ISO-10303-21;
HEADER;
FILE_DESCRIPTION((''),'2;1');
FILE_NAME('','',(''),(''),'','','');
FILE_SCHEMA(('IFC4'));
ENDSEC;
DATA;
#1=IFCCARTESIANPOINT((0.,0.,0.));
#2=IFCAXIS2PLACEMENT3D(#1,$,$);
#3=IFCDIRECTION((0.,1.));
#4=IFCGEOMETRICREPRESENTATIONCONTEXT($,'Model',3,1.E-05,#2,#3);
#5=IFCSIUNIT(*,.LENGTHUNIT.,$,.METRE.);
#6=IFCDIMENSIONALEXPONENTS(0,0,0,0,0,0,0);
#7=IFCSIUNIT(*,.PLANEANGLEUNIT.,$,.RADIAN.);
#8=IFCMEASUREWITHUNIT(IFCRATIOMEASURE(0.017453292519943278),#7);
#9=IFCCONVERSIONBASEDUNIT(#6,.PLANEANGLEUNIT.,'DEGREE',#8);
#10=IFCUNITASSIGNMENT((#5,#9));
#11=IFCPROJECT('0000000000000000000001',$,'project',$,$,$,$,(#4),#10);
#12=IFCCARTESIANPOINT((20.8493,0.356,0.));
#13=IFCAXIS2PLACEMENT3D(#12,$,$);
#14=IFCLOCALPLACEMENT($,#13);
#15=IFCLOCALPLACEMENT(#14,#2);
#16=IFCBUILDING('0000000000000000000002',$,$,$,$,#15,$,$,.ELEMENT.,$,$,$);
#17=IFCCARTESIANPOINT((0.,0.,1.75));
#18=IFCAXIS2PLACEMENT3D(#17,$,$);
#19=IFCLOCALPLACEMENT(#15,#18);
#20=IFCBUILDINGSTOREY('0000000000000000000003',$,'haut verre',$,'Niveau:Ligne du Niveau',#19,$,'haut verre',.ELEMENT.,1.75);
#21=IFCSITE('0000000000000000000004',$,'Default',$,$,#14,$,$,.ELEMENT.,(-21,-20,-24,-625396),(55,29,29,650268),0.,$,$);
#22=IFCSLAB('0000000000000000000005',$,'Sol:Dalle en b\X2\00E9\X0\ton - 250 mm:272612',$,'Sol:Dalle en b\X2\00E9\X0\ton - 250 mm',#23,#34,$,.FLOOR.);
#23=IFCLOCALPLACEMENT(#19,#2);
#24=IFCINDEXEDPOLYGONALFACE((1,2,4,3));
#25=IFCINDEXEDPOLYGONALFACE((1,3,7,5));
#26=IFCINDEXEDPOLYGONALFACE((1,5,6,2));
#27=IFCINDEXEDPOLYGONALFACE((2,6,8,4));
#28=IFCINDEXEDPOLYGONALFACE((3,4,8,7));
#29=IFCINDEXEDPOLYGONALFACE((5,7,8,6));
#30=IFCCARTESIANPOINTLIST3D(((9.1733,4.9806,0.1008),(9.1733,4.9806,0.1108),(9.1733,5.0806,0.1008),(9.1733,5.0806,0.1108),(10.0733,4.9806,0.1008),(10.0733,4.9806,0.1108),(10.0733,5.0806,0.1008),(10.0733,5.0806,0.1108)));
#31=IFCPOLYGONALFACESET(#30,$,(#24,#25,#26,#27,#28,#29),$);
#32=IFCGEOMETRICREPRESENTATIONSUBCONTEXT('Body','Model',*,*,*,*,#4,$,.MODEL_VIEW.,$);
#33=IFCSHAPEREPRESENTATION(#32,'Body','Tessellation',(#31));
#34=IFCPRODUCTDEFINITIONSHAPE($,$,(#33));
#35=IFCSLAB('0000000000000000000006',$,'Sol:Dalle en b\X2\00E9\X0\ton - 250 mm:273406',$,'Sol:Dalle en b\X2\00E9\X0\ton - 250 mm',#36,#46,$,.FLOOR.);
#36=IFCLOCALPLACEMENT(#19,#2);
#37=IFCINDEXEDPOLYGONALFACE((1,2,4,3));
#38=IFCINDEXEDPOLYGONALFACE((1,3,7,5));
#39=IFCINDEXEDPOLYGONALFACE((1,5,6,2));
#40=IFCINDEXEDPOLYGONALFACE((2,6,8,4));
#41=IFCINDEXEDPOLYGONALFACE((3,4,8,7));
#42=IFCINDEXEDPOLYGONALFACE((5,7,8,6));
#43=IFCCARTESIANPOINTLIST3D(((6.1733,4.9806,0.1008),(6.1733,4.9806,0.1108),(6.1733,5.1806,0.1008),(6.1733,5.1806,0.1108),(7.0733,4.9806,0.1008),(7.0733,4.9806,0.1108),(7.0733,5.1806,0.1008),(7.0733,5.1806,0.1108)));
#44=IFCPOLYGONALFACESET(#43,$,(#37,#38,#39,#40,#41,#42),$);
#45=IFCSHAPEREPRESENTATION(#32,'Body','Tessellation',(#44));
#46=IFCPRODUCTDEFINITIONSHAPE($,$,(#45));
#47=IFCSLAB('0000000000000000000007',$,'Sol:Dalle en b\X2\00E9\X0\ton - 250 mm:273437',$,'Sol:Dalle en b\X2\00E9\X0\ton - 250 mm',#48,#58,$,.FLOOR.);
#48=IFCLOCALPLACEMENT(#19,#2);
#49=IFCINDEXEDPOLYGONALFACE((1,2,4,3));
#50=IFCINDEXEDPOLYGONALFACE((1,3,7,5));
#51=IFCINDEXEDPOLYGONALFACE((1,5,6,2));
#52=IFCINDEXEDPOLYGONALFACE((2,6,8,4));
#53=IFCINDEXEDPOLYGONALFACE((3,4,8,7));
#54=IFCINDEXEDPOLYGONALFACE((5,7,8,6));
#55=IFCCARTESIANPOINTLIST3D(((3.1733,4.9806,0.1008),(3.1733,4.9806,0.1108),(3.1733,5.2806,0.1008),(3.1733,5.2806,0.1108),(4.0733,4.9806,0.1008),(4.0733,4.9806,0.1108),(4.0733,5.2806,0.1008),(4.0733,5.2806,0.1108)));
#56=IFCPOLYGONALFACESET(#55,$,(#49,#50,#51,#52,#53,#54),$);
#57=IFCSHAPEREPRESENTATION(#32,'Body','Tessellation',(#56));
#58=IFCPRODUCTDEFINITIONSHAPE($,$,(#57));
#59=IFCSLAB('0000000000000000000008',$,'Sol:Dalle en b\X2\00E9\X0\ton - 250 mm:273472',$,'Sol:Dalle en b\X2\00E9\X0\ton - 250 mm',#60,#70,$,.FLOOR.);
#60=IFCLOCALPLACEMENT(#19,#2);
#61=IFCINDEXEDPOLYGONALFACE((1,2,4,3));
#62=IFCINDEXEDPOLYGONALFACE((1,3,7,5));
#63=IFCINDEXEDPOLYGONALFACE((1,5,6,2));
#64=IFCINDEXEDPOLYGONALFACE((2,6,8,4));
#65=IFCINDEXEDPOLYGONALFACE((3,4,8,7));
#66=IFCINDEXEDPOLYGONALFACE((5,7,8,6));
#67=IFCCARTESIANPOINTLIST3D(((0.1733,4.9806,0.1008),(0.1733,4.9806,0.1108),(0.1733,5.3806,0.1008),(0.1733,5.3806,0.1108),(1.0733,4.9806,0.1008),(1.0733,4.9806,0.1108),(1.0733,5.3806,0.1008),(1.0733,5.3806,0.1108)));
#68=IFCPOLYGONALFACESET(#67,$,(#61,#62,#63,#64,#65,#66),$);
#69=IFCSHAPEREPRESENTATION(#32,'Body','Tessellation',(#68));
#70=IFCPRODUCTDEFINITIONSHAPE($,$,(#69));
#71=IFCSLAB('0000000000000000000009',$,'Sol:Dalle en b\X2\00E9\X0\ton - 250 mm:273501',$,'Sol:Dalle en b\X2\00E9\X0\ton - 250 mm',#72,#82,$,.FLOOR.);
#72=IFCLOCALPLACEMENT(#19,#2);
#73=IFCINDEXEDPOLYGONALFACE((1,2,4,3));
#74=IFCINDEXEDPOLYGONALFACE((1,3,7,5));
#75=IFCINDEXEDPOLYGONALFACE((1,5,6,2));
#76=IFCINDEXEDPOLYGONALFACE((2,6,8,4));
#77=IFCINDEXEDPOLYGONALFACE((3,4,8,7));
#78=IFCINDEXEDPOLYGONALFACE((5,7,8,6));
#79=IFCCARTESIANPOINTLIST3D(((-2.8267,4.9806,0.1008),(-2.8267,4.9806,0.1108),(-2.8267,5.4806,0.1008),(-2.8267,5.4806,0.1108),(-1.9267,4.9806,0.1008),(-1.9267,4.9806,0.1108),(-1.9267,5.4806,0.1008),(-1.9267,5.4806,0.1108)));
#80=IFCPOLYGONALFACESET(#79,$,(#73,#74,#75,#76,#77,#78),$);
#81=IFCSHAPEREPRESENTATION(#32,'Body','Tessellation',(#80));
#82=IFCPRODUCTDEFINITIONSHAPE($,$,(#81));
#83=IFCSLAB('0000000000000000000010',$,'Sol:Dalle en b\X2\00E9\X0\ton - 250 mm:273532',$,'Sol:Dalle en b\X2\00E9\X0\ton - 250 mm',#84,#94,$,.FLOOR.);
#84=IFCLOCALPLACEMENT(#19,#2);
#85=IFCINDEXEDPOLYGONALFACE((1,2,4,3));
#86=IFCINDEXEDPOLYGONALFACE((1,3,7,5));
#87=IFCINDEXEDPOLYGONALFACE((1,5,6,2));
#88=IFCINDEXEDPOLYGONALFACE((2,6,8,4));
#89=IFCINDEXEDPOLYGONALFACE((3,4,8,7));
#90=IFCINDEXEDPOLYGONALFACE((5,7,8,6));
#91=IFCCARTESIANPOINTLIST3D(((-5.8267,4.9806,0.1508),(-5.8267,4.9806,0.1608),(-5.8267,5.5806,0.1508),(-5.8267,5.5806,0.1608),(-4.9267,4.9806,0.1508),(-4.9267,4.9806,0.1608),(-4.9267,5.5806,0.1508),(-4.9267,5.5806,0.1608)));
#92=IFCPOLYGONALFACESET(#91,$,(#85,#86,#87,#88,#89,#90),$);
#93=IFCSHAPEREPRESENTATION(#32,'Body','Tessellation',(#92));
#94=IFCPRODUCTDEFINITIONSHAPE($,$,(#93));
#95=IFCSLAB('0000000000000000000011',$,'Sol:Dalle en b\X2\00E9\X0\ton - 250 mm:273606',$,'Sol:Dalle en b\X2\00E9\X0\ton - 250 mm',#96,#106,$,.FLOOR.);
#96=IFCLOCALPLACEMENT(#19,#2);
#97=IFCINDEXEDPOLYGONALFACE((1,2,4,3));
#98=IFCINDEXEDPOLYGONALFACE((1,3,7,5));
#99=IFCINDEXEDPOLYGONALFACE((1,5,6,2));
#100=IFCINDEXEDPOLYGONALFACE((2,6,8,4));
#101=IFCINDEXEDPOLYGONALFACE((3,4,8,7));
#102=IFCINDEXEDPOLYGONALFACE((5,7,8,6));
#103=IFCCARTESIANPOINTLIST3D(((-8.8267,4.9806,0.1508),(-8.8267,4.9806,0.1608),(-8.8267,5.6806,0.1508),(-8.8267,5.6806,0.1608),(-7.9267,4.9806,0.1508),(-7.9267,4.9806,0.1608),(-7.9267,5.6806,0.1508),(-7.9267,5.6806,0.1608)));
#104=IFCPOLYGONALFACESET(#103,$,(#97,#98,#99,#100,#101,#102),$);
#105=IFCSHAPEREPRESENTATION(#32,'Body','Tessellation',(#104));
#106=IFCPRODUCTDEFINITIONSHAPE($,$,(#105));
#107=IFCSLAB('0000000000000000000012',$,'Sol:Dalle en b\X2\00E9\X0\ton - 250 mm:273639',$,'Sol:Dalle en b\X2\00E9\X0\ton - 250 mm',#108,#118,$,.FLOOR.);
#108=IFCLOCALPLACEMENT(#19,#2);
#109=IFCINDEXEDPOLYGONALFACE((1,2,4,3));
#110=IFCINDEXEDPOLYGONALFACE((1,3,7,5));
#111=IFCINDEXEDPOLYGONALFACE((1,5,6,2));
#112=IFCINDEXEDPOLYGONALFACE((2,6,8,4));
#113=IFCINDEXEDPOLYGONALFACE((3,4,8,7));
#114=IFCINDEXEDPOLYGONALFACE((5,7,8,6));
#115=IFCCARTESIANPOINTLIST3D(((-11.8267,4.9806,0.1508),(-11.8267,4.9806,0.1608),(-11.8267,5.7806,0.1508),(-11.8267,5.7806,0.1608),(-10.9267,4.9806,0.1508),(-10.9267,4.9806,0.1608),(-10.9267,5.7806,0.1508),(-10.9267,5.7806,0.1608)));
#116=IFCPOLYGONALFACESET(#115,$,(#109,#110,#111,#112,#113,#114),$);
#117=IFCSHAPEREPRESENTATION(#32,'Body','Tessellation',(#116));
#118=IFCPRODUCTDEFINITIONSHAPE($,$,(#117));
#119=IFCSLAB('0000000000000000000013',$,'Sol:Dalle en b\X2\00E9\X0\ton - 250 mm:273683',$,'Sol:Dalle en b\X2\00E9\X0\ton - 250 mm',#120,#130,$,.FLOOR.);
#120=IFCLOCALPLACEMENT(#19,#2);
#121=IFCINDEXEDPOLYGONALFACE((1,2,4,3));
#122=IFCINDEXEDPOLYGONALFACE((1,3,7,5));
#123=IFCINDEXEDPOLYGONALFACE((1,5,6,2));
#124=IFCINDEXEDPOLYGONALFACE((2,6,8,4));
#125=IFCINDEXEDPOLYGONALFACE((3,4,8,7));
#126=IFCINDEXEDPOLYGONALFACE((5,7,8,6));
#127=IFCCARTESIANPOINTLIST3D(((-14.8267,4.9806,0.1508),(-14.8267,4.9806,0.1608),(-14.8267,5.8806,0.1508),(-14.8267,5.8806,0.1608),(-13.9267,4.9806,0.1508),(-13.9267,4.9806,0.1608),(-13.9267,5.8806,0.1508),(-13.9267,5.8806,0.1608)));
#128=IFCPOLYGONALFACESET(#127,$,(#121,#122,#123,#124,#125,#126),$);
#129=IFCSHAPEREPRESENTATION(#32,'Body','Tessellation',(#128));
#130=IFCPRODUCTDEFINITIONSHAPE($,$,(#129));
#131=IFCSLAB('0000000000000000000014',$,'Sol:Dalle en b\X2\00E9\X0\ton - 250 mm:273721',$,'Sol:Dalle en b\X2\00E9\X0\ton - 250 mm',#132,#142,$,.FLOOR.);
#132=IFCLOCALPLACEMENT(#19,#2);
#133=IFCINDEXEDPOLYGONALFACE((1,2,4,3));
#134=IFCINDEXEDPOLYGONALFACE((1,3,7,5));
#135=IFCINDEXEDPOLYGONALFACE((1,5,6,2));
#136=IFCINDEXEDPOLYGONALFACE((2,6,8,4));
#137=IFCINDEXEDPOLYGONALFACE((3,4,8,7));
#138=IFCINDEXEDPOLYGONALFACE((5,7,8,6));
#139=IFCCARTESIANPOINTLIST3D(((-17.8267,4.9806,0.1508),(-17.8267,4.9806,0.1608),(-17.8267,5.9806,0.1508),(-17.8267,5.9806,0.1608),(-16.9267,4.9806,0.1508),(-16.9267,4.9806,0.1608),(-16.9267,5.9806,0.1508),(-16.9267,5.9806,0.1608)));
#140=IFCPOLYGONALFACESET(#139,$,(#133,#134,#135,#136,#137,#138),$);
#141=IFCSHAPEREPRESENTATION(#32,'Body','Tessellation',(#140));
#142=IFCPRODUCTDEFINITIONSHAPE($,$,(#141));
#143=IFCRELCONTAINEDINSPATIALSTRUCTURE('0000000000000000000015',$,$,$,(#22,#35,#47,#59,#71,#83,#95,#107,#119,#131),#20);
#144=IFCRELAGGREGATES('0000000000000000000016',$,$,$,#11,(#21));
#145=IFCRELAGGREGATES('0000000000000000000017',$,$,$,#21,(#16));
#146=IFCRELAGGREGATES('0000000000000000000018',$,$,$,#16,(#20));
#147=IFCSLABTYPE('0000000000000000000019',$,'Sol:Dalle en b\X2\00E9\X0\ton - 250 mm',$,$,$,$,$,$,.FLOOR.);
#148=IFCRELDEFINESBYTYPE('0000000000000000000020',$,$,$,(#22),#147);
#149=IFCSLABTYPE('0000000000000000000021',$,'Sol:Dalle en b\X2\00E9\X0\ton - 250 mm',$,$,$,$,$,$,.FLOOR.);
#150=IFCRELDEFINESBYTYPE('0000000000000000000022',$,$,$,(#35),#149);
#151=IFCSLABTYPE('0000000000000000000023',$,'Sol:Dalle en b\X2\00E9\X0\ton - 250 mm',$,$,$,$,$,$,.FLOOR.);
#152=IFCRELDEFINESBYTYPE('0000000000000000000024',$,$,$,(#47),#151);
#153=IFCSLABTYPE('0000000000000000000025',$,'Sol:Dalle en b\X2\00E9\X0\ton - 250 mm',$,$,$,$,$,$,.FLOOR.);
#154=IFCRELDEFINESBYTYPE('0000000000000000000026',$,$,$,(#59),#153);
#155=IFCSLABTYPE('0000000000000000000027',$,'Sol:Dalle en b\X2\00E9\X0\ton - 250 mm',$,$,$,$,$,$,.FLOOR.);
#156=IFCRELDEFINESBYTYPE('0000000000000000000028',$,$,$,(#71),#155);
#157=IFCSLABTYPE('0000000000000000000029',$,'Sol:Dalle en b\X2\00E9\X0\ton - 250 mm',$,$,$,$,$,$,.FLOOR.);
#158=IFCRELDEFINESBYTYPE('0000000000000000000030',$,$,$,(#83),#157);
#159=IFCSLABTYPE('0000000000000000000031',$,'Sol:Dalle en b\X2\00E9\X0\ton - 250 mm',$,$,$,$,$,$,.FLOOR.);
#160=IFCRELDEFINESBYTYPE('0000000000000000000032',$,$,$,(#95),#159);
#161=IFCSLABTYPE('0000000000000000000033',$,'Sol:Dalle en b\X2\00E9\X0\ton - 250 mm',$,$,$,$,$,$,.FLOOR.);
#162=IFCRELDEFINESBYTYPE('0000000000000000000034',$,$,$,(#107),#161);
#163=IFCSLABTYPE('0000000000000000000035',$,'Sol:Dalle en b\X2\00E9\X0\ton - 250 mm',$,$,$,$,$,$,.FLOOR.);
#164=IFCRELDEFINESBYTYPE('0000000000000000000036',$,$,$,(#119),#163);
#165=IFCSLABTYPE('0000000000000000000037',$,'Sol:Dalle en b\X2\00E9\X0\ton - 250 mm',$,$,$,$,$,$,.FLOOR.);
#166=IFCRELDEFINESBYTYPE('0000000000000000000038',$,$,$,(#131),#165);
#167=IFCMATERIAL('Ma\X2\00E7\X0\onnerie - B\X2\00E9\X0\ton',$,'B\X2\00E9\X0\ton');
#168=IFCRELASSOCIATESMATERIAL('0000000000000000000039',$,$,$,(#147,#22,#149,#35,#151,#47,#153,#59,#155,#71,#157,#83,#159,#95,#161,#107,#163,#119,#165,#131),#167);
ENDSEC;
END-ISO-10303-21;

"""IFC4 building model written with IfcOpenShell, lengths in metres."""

from ifc_helpers import new_model, entity, si_unit, converted_unit, direction, frame, origin, place, context, subcontext, project, spatial, indexed_curve, outline, extrude, material, type_object, element, save


model = new_model("IFC4")

# Units and contexts
model_context = context("Model", 3, precision=1e-05, world=origin(), true_north=direction((0.0, 1.0)))
body_context = subcontext(model_context, "Body", "Model", "MODEL_VIEW")
ifc_project = project(units=[si_unit("LENGTHUNIT", "METRE"), converted_unit("PLANEANGLEUNIT", "DEGREE", entity("IfcRatioMeasure", 0.017453292519943278), si_unit("PLANEANGLEUNIT", "RADIAN"), dimensions=[0, 0, 0, 0, 0, 0, 0])], contexts=[model_context])

# Site, building, storey
site_placement = place(None, frame((20.8493, 0.356, 0.0)))
site = spatial("IfcSite", under=ifc_project, at=site_placement, Name="Default", CompositionType="ELEMENT", RefLatitude=(-21, -20, -24, -625396), RefLongitude=(55, 29, 29, 650268), RefElevation=0.0)
building_placement = place(site_placement, origin())
building = spatial("IfcBuilding", under=site, at=building_placement, CompositionType="ELEMENT")
storey_placement = place(building_placement, frame((0.0, 0.0, 1.75)))
storey = spatial("IfcBuildingStorey", under=building, at=storey_placement, Name="haut verre", ObjectType="Niveau:Ligne du Niveau", LongName="haut verre", CompositionType="ELEMENT", Elevation=1.75)

# Slabs
ifc_material = material(Name="Maçonnerie - Béton", Category="Béton")
slab_type_1 = type_object("IfcSlabType", Name="Sol:Dalle en béton - 250 mm", PredefinedType="FLOOR", material=ifc_material)
slab_1_placement = place(storey_placement, origin())
element("IfcSlab", 1, at=slab_1_placement, inside=storey, type_object=slab_type_1, material=ifc_material, Name="Sol:Dalle en béton - 250 mm:272612", ObjectType="Sol:Dalle en béton - 250 mm", PredefinedType="FLOOR", context=body_context, shape_type="SweptSolid", body=[
    extrude(outline(indexed_curve([(-0.05, -0.45), (0.05, -0.45), (0.05, 0.45), (-0.05, 0.45), (-0.05, -0.45)], self_intersect=False)), frame((9.6233, 5.0306, 0.1108), z_axis=(0.0, 0.0, -1.0), x_axis=(0.0, 1.0, 0.0)), (0.0, 0.0, 1.0), 0.01),
])
slab_type_2 = type_object("IfcSlabType", Name="Sol:Dalle en béton - 250 mm", PredefinedType="FLOOR", material=ifc_material)
slab_2_placement = place(storey_placement, origin())
element("IfcSlab", 2, at=slab_2_placement, inside=storey, type_object=slab_type_2, material=ifc_material, Name="Sol:Dalle en béton - 250 mm:273406", ObjectType="Sol:Dalle en béton - 250 mm", PredefinedType="FLOOR", context=body_context, shape_type="SweptSolid", body=[
    extrude(outline(indexed_curve([(-0.1, -0.45), (0.1, -0.45), (0.1, 0.45), (-0.1, 0.45), (-0.1, -0.45)], self_intersect=False)), frame((6.6233, 5.0806, 0.1108), z_axis=(0.0, 0.0, -1.0), x_axis=(0.0, 1.0, 0.0)), (0.0, 0.0, 1.0), 0.01),
])
slab_type_3 = type_object("IfcSlabType", Name="Sol:Dalle en béton - 250 mm", PredefinedType="FLOOR", material=ifc_material)
slab_3_placement = place(storey_placement, origin())
element("IfcSlab", 3, at=slab_3_placement, inside=storey, type_object=slab_type_3, material=ifc_material, Name="Sol:Dalle en béton - 250 mm:273437", ObjectType="Sol:Dalle en béton - 250 mm", PredefinedType="FLOOR", context=body_context, shape_type="SweptSolid", body=[
    extrude(outline(indexed_curve([(-0.15, -0.45), (0.15, -0.45), (0.15, 0.45), (-0.15, 0.45), (-0.15, -0.45)], self_intersect=False)), frame((3.6233, 5.1306, 0.1108), z_axis=(0.0, 0.0, -1.0), x_axis=(0.0, 1.0, 0.0)), (0.0, 0.0, 1.0), 0.01),
])
slab_type_4 = type_object("IfcSlabType", Name="Sol:Dalle en béton - 250 mm", PredefinedType="FLOOR", material=ifc_material)
slab_4_placement = place(storey_placement, origin())
element("IfcSlab", 4, at=slab_4_placement, inside=storey, type_object=slab_type_4, material=ifc_material, Name="Sol:Dalle en béton - 250 mm:273472", ObjectType="Sol:Dalle en béton - 250 mm", PredefinedType="FLOOR", context=body_context, shape_type="SweptSolid", body=[
    extrude(outline(indexed_curve([(-0.2, -0.45), (0.2, -0.45), (0.2, 0.45), (-0.2, 0.45), (-0.2, -0.45)], self_intersect=False)), frame((0.6233, 5.1806, 0.1108), z_axis=(0.0, 0.0, -1.0), x_axis=(0.0, 1.0, 0.0)), (0.0, 0.0, 1.0), 0.01),
])
slab_type_5 = type_object("IfcSlabType", Name="Sol:Dalle en béton - 250 mm", PredefinedType="FLOOR", material=ifc_material)
slab_5_placement = place(storey_placement, origin())
element("IfcSlab", 5, at=slab_5_placement, inside=storey, type_object=slab_type_5, material=ifc_material, Name="Sol:Dalle en béton - 250 mm:273501", ObjectType="Sol:Dalle en béton - 250 mm", PredefinedType="FLOOR", context=body_context, shape_type="SweptSolid", body=[
    extrude(outline(indexed_curve([(-0.25, -0.45), (0.25, -0.45), (0.25, 0.45), (-0.25, 0.45), (-0.25, -0.45)], self_intersect=False)), frame((-2.3767, 5.2306, 0.1108), z_axis=(0.0, 0.0, -1.0), x_axis=(0.0, 1.0, 0.0)), (0.0, 0.0, 1.0), 0.01),
])
slab_type_6 = type_object("IfcSlabType", Name="Sol:Dalle en béton - 250 mm", PredefinedType="FLOOR", material=ifc_material)
slab_6_placement = place(storey_placement, origin())
element("IfcSlab", 6, at=slab_6_placement, inside=storey, type_object=slab_type_6, material=ifc_material, Name="Sol:Dalle en béton - 250 mm:273532", ObjectType="Sol:Dalle en béton - 250 mm", PredefinedType="FLOOR", context=body_context, shape_type="SweptSolid", body=[
    extrude(outline(indexed_curve([(-0.3, -0.45), (0.3, -0.45), (0.3, 0.45), (-0.3, 0.45), (-0.3, -0.45)], self_intersect=False)), frame((-5.3767, 5.2806, 0.1608), z_axis=(0.0, 0.0, -1.0), x_axis=(0.0, 1.0, 0.0)), (0.0, 0.0, 1.0), 0.01),
])
slab_type_7 = type_object("IfcSlabType", Name="Sol:Dalle en béton - 250 mm", PredefinedType="FLOOR", material=ifc_material)
slab_7_placement = place(storey_placement, origin())
element("IfcSlab", 7, at=slab_7_placement, inside=storey, type_object=slab_type_7, material=ifc_material, Name="Sol:Dalle en béton - 250 mm:273606", ObjectType="Sol:Dalle en béton - 250 mm", PredefinedType="FLOOR", context=body_context, shape_type="SweptSolid", body=[
    extrude(outline(indexed_curve([(-0.35, -0.45), (0.35, -0.45), (0.35, 0.45), (-0.35, 0.45), (-0.35, -0.45)], self_intersect=False)), frame((-8.3767, 5.3306, 0.1608), z_axis=(0.0, 0.0, -1.0), x_axis=(0.0, 1.0, 0.0)), (0.0, 0.0, 1.0), 0.01),
])
slab_type_8 = type_object("IfcSlabType", Name="Sol:Dalle en béton - 250 mm", PredefinedType="FLOOR", material=ifc_material)
slab_8_placement = place(storey_placement, origin())
element("IfcSlab", 8, at=slab_8_placement, inside=storey, type_object=slab_type_8, material=ifc_material, Name="Sol:Dalle en béton - 250 mm:273639", ObjectType="Sol:Dalle en béton - 250 mm", PredefinedType="FLOOR", context=body_context, shape_type="SweptSolid", body=[
    extrude(outline(indexed_curve([(-0.4, -0.45), (0.4, -0.45), (0.4, 0.45), (-0.4, 0.45), (-0.4, -0.45)], self_intersect=False)), frame((-11.3767, 5.3806, 0.1608), z_axis=(0.0, 0.0, -1.0), x_axis=(0.0, 1.0, 0.0)), (0.0, 0.0, 1.0), 0.01),
])
slab_type_9 = type_object("IfcSlabType", Name="Sol:Dalle en béton - 250 mm", PredefinedType="FLOOR", material=ifc_material)
slab_9_placement = place(storey_placement, origin())
element("IfcSlab", 9, at=slab_9_placement, inside=storey, type_object=slab_type_9, material=ifc_material, Name="Sol:Dalle en béton - 250 mm:273683", ObjectType="Sol:Dalle en béton - 250 mm", PredefinedType="FLOOR", context=body_context, shape_type="SweptSolid", body=[
    extrude(outline(indexed_curve([(-0.45, -0.45), (0.45, -0.45), (0.45, 0.45), (-0.45, 0.45), (-0.45, -0.45)], self_intersect=False)), frame((-14.3767, 5.4306, 0.1608), z_axis=(0.0, 0.0, -1.0), x_axis=(0.0, 1.0, 0.0)), (0.0, 0.0, 1.0), 0.01),
])
slab_type_10 = type_object("IfcSlabType", Name="Sol:Dalle en béton - 250 mm", PredefinedType="FLOOR", material=ifc_material)
slab_10_placement = place(storey_placement, origin())
element("IfcSlab", 10, at=slab_10_placement, inside=storey, type_object=slab_type_10, material=ifc_material, Name="Sol:Dalle en béton - 250 mm:273721", ObjectType="Sol:Dalle en béton - 250 mm", PredefinedType="FLOOR", context=body_context, shape_type="SweptSolid", body=[
    extrude(outline(indexed_curve([(-0.5, -0.45), (0.5, -0.45), (0.5, 0.45), (-0.5, 0.45), (-0.5, -0.45)], self_intersect=False)), frame((-17.3767, 5.4806, 0.1608), z_axis=(0.0, 0.0, -1.0), x_axis=(0.0, 1.0, 0.0)), (0.0, 0.0, 1.0), 0.01),
])

save(model, "model.ifc")
